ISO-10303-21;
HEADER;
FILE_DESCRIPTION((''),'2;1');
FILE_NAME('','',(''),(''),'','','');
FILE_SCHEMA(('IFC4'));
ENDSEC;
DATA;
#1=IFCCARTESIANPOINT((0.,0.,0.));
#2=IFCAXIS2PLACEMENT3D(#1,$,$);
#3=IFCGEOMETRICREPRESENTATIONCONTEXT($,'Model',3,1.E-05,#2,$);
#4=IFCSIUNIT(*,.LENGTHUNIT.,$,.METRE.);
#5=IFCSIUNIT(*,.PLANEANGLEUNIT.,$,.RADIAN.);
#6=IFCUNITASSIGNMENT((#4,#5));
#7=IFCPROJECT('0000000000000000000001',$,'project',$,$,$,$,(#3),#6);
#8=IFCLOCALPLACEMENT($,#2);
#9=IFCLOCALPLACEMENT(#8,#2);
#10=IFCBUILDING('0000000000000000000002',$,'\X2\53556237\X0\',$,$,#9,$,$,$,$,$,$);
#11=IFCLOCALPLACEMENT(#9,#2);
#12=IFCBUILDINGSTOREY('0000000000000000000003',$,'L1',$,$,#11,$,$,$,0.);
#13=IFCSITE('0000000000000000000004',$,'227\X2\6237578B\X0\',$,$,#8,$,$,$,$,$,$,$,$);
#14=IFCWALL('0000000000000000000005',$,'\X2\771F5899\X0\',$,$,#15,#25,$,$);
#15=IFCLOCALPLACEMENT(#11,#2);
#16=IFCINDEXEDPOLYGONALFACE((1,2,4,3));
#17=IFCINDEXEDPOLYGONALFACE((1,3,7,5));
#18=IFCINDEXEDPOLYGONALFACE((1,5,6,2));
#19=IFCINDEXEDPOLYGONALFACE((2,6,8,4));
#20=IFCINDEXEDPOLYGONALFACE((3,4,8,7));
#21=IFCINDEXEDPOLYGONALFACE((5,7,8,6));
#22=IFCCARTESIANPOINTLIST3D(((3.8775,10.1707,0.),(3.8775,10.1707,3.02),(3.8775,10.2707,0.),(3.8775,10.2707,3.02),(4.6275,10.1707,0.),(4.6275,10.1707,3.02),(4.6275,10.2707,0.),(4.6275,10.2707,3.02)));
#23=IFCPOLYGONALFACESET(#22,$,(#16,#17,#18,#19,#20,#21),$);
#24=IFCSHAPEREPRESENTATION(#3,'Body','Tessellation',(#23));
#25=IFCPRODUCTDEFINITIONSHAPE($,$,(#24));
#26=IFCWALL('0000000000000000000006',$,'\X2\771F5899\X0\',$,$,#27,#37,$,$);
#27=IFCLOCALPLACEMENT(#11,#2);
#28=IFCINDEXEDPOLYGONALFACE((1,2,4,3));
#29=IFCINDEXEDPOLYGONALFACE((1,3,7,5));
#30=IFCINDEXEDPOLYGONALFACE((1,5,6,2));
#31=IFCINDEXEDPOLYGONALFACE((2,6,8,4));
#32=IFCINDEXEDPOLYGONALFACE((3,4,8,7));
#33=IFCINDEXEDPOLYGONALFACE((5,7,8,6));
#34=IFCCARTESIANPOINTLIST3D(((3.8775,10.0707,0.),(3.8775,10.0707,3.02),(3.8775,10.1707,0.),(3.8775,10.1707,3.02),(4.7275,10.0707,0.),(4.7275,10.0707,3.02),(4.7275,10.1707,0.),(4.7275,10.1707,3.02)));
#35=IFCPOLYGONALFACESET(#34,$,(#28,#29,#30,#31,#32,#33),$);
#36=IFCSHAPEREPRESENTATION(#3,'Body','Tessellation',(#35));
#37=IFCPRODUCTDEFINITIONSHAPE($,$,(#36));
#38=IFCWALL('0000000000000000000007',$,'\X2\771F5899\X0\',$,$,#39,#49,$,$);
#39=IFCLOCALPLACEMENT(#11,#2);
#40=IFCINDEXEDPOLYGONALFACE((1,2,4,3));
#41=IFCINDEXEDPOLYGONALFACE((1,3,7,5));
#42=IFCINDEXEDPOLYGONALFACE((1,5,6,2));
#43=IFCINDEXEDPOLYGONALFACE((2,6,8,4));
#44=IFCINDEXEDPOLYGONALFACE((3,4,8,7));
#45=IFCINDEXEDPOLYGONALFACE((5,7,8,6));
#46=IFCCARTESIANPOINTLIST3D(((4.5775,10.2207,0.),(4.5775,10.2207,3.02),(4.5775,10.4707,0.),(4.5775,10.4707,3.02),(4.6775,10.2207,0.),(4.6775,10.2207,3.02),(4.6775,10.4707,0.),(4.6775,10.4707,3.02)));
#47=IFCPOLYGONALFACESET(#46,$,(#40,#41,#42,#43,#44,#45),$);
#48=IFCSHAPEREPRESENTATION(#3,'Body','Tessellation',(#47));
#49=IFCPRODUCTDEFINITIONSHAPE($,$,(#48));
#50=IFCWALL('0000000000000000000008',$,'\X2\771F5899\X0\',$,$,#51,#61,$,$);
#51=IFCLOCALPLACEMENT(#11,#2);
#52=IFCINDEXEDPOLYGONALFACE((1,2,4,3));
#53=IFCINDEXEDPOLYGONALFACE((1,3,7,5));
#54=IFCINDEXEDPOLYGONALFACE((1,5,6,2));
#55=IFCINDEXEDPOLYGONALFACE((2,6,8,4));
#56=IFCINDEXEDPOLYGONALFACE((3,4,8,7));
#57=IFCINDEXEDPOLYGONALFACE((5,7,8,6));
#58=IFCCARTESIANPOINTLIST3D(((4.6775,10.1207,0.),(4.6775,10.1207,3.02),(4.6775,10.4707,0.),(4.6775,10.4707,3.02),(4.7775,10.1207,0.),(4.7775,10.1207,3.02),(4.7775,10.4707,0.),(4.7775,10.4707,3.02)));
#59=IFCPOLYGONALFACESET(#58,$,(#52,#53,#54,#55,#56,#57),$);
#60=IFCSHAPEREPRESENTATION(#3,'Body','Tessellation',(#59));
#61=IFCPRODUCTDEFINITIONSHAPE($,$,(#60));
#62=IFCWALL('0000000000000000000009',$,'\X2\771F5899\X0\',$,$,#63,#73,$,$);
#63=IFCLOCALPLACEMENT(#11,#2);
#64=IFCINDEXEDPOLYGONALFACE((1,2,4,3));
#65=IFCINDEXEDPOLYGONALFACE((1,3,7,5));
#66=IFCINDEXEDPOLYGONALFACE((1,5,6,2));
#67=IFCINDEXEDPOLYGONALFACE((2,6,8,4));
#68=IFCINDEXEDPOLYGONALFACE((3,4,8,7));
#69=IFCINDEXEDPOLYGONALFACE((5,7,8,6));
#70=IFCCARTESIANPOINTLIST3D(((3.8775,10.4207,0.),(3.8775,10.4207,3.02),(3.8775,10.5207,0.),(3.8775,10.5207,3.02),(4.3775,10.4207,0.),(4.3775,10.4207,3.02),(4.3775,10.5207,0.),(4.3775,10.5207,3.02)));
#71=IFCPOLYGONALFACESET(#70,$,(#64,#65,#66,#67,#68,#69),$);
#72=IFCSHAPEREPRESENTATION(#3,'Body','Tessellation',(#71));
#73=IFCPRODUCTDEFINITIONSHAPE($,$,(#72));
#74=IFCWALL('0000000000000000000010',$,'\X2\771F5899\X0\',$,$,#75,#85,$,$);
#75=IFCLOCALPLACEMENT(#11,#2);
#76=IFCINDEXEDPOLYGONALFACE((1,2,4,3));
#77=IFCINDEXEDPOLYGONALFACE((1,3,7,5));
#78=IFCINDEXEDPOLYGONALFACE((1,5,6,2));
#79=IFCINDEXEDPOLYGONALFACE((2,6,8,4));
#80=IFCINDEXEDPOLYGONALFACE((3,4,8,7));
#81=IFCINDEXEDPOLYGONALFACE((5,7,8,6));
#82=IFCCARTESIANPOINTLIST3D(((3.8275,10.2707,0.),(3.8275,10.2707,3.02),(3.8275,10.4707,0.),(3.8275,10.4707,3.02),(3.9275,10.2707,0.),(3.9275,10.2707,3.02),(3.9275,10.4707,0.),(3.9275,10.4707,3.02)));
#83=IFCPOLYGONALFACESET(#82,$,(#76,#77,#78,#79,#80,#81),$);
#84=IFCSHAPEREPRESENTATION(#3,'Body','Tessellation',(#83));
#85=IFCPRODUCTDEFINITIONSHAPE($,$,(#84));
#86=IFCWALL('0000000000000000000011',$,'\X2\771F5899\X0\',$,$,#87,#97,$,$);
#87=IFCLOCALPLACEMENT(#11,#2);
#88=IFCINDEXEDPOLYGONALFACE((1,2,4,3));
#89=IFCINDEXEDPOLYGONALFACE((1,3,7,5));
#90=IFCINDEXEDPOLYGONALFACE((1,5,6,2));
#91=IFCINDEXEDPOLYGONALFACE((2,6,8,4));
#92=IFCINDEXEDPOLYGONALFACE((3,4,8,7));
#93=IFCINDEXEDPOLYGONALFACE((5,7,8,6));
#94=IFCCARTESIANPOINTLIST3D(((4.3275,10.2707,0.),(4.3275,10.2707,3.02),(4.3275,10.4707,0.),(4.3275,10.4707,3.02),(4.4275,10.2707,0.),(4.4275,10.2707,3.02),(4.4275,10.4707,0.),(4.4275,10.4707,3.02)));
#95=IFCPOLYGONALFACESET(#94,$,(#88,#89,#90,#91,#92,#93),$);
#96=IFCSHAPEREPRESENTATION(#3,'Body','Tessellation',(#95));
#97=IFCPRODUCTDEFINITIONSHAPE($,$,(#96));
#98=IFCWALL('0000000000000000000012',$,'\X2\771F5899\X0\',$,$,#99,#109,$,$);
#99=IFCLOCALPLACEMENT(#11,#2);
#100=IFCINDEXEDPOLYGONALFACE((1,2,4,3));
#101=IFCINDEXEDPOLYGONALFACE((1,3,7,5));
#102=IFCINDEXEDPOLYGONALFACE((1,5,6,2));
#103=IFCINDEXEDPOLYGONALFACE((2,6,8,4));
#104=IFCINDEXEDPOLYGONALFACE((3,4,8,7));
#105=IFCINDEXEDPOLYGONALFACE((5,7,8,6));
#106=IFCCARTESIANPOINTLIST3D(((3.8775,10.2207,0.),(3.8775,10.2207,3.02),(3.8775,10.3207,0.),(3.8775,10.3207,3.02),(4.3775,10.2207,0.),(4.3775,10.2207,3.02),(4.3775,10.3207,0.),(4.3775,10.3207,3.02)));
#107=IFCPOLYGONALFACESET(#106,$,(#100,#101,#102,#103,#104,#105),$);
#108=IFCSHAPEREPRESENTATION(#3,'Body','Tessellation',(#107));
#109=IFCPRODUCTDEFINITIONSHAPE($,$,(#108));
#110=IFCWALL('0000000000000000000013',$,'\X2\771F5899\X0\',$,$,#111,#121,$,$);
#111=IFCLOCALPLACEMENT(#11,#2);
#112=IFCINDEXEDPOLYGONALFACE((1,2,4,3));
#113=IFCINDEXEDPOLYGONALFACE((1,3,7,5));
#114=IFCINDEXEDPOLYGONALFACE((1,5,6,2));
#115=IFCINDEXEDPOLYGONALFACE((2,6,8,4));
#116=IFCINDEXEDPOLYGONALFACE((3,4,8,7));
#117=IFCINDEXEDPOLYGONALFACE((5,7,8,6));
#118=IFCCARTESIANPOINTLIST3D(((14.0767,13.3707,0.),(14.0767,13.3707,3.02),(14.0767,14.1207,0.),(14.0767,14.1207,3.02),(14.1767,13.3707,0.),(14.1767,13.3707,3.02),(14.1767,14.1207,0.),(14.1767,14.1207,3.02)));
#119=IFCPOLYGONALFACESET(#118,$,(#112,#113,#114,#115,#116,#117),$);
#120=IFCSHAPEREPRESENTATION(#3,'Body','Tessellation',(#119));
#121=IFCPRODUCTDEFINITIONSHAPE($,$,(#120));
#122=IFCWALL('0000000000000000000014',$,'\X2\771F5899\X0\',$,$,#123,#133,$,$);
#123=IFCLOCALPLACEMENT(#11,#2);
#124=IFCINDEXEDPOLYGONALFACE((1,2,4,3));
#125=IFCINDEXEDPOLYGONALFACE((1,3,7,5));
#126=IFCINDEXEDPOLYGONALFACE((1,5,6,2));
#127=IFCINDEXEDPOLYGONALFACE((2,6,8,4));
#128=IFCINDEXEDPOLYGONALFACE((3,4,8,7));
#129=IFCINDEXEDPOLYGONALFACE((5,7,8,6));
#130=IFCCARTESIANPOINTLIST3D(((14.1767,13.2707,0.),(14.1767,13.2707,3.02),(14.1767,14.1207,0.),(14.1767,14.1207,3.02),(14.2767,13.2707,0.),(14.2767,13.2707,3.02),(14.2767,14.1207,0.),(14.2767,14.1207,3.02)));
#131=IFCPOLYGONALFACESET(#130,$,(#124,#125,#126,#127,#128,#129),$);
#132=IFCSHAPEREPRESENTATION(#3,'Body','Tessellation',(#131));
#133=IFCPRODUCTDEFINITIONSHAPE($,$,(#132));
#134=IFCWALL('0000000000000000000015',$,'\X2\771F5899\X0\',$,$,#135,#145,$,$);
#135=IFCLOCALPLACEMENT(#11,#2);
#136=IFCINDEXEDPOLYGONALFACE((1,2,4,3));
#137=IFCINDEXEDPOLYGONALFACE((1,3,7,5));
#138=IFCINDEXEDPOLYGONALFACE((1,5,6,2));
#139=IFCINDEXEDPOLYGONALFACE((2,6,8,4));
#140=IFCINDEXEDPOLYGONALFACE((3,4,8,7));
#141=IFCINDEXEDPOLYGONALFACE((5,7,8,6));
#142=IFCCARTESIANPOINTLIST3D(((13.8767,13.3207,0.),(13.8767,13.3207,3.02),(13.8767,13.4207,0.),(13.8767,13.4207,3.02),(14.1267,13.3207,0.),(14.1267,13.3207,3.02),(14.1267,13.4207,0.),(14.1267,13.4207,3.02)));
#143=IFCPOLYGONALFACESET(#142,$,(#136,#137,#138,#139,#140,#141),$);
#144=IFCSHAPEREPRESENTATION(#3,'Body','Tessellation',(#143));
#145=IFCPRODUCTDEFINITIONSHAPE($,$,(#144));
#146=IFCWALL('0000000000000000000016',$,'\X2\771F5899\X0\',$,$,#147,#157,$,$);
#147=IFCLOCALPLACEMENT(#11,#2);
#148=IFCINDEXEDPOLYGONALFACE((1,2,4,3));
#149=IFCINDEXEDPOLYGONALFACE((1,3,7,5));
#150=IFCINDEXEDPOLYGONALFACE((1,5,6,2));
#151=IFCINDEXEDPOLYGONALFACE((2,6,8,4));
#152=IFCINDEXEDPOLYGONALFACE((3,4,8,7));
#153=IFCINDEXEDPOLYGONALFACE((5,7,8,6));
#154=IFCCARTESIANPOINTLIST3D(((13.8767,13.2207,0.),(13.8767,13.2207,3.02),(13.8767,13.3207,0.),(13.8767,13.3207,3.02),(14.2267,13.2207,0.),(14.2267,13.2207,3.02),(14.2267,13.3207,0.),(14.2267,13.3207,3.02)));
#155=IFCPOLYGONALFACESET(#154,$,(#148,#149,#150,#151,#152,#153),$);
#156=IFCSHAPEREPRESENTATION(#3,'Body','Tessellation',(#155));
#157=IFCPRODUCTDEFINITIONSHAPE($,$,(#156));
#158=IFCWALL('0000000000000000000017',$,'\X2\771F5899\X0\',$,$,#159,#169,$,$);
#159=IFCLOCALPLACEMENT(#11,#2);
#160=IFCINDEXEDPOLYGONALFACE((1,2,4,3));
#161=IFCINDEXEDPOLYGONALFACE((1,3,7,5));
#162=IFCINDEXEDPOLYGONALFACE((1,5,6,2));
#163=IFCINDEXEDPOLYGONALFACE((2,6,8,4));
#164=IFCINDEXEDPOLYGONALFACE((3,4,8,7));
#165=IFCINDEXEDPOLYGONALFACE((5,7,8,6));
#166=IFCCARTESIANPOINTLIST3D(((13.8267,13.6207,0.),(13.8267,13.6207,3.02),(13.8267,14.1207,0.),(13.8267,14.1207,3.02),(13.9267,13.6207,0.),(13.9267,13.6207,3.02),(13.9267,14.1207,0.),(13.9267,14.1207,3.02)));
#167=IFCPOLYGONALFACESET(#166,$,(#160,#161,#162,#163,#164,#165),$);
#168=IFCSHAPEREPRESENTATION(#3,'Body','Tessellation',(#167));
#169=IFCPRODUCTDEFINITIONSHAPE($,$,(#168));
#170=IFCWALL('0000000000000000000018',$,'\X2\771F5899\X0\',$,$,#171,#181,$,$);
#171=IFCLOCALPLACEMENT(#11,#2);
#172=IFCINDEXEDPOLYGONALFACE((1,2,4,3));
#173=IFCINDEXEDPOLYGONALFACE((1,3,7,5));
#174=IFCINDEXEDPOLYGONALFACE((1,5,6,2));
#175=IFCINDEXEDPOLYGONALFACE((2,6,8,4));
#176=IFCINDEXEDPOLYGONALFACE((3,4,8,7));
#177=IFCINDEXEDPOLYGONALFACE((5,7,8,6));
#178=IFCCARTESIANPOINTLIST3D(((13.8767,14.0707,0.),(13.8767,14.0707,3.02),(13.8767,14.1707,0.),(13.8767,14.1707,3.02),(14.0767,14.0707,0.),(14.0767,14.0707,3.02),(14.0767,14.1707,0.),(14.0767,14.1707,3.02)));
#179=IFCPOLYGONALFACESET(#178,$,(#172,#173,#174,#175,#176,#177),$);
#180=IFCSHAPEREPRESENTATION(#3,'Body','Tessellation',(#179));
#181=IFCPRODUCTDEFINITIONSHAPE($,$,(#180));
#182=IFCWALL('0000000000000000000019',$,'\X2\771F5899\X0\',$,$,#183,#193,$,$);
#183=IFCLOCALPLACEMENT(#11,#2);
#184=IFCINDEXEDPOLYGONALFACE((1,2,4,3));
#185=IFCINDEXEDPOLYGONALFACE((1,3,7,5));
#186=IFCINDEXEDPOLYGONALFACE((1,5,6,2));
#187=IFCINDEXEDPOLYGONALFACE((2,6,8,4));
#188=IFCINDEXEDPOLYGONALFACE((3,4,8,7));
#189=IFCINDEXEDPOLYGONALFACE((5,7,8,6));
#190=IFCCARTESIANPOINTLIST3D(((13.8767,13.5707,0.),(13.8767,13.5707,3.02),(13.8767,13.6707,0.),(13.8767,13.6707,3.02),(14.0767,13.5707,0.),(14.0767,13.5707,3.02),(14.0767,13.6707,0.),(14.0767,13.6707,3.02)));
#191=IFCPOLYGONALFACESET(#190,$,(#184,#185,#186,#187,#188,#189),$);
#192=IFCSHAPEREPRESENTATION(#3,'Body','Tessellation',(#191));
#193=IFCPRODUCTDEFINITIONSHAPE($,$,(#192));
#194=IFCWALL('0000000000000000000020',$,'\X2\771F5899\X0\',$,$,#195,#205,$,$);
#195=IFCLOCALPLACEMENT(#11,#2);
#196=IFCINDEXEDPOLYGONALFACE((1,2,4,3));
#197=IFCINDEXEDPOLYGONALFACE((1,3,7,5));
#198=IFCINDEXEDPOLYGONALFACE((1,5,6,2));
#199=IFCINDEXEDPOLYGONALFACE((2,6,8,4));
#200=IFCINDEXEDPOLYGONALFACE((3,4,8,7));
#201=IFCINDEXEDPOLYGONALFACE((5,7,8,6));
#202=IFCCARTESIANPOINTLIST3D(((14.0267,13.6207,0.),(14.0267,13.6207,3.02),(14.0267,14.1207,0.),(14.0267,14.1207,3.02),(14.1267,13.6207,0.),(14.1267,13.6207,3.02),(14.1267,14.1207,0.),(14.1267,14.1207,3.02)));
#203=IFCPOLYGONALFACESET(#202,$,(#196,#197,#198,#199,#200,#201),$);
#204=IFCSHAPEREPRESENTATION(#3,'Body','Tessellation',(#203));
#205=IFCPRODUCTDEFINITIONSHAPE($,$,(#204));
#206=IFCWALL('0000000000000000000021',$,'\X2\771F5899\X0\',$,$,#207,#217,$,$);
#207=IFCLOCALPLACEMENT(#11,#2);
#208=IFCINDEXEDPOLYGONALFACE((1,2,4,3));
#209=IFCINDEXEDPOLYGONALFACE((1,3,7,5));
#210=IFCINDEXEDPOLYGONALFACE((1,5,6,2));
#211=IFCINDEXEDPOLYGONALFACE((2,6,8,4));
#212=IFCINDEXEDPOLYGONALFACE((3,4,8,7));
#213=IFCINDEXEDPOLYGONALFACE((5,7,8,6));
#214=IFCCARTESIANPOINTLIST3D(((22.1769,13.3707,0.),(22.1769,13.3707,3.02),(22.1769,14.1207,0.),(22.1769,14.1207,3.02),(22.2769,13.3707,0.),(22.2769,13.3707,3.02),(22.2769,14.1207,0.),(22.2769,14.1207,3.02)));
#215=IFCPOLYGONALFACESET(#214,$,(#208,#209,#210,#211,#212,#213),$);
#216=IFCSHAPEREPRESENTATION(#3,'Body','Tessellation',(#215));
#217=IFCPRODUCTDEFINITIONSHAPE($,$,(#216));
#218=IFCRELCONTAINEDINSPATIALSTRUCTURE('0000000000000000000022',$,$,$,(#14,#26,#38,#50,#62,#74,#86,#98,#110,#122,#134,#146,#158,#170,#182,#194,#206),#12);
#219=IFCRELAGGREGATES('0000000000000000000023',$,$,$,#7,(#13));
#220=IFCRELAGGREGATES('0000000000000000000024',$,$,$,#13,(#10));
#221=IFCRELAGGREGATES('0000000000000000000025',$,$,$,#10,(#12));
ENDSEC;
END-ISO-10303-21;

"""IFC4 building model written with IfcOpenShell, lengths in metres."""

from ifc_helpers import new_model, si_unit, origin, place, context, project, spatial, polyline, outline, extrude, element, save


model = new_model("IFC4")

# Units and contexts
model_context = context("Model", 3, precision=1e-05, world=origin())
ifc_project = project(units=[si_unit("LENGTHUNIT", "METRE"), si_unit("PLANEANGLEUNIT", "RADIAN")], contexts=[model_context])

# Site, building, storey
site_placement = place(None, origin())
site = spatial("IfcSite", under=ifc_project, at=site_placement, Name="227户型")
building_placement = place(site_placement, origin())
building = spatial("IfcBuilding", under=site, at=building_placement, Name="单户")
storey_placement = place(building_placement, origin())
storey = spatial("IfcBuildingStorey", under=building, at=storey_placement, Name="L1", Elevation=0.0)

# Walls
wall_1_placement = place(storey_placement, origin())
element("IfcWall", 1, at=wall_1_placement, inside=storey, Name="真墙", context=model_context, shape_type="SweptSolid", body=[
    extrude(outline(polyline([(4.6275, 10.1707), (3.8775, 10.1707), (3.8775, 10.2707), (4.6275, 10.2707), (4.6275, 10.1707)])), origin(), (0.0, 0.0, 1.0), 3.02),
])
wall_2_placement = place(storey_placement, origin())
element("IfcWall", 2, at=wall_2_placement, inside=storey, Name="真墙", context=model_context, shape_type="SweptSolid", body=[
    extrude(outline(polyline([(3.8775, 10.1707), (4.7275, 10.1707), (4.7275, 10.0707), (3.8775, 10.0707), (3.8775, 10.1707)])), origin(), (0.0, 0.0, 1.0), 3.02),
])
wall_3_placement = place(storey_placement, origin())
element("IfcWall", 3, at=wall_3_placement, inside=storey, Name="真墙", context=model_context, shape_type="SweptSolid", body=[
    extrude(outline(polyline([(4.5775, 10.2207), (4.5775, 10.4707), (4.6775, 10.4707), (4.6775, 10.2207), (4.5775, 10.2207)])), origin(), (0.0, 0.0, 1.0), 3.02),
])
wall_4_placement = place(storey_placement, origin())
element("IfcWall", 4, at=wall_4_placement, inside=storey, Name="真墙", context=model_context, shape_type="SweptSolid", body=[
    extrude(outline(polyline([(4.6775, 10.1207), (4.6775, 10.4707), (4.7775, 10.4707), (4.7775, 10.1207), (4.6775, 10.1207)])), origin(), (0.0, 0.0, 1.0), 3.02),
])
wall_5_placement = place(storey_placement, origin())
element("IfcWall", 5, at=wall_5_placement, inside=storey, Name="真墙", context=model_context, shape_type="SweptSolid", body=[
    extrude(outline(polyline([(4.3775, 10.4207), (3.8775, 10.4207), (3.8775, 10.5207), (4.3775, 10.5207), (4.3775, 10.4207)])), origin(), (0.0, 0.0, 1.0), 3.02),
])
wall_6_placement = place(storey_placement, origin())
element("IfcWall", 6, at=wall_6_placement, inside=storey, Name="真墙", context=model_context, shape_type="SweptSolid", body=[
    extrude(outline(polyline([(3.9275, 10.4707), (3.9275, 10.2707), (3.8275, 10.2707), (3.8275, 10.4707), (3.9275, 10.4707)])), origin(), (0.0, 0.0, 1.0), 3.02),
])
wall_7_placement = place(storey_placement, origin())
element("IfcWall", 7, at=wall_7_placement, inside=storey, Name="真墙", context=model_context, shape_type="SweptSolid", body=[
    extrude(outline(polyline([(4.4275, 10.4707), (4.4275, 10.2707), (4.3275, 10.2707), (4.3275, 10.4707), (4.4275, 10.4707)])), origin(), (0.0, 0.0, 1.0), 3.02),
])
wall_8_placement = place(storey_placement, origin())
element("IfcWall", 8, at=wall_8_placement, inside=storey, Name="真墙", context=model_context, shape_type="SweptSolid", body=[
    extrude(outline(polyline([(4.3775, 10.2207), (3.8775, 10.2207), (3.8775, 10.3207), (4.3775, 10.3207), (4.3775, 10.2207)])), origin(), (0.0, 0.0, 1.0), 3.02),
])
wall_9_placement = place(storey_placement, origin())
element("IfcWall", 9, at=wall_9_placement, inside=storey, Name="真墙", context=model_context, shape_type="SweptSolid", body=[
    extrude(outline(polyline([(14.0767, 13.3707), (14.0767, 14.1207), (14.1767, 14.1207), (14.1767, 13.3707), (14.0767, 13.3707)])), origin(), (0.0, 0.0, 1.0), 3.02),
])
wall_10_placement = place(storey_placement, origin())
element("IfcWall", 10, at=wall_10_placement, inside=storey, Name="真墙", context=model_context, shape_type="SweptSolid", body=[
    extrude(outline(polyline([(14.2767, 14.1207), (14.2767, 13.2707), (14.1767, 13.2707), (14.1767, 14.1207), (14.2767, 14.1207)])), origin(), (0.0, 0.0, 1.0), 3.02),
])
wall_11_placement = place(storey_placement, origin())
element("IfcWall", 11, at=wall_11_placement, inside=storey, Name="真墙", context=model_context, shape_type="SweptSolid", body=[
    extrude(outline(polyline([(14.1267, 13.3207), (13.8767, 13.3207), (13.8767, 13.4207), (14.1267, 13.4207), (14.1267, 13.3207)])), origin(), (0.0, 0.0, 1.0), 3.02),
])
wall_12_placement = place(storey_placement, origin())
element("IfcWall", 12, at=wall_12_placement, inside=storey, Name="真墙", context=model_context, shape_type="SweptSolid", body=[
    extrude(outline(polyline([(14.2267, 13.2207), (13.8767, 13.2207), (13.8767, 13.3207), (14.2267, 13.3207), (14.2267, 13.2207)])), origin(), (0.0, 0.0, 1.0), 3.02),
])
wall_13_placement = place(storey_placement, origin())
element("IfcWall", 13, at=wall_13_placement, inside=storey, Name="真墙", context=model_context, shape_type="SweptSolid", body=[
    extrude(outline(polyline([(13.8267, 13.6207), (13.8267, 14.1207), (13.9267, 14.1207), (13.9267, 13.6207), (13.8267, 13.6207)])), origin(), (0.0, 0.0, 1.0), 3.02),
])
wall_14_placement = place(storey_placement, origin())
element("IfcWall", 14, at=wall_14_placement, inside=storey, Name="真墙", context=model_context, shape_type="SweptSolid", body=[
    extrude(outline(polyline([(13.8767, 14.1707), (14.0767, 14.1707), (14.0767, 14.0707), (13.8767, 14.0707), (13.8767, 14.1707)])), origin(), (0.0, 0.0, 1.0), 3.02),
])
wall_15_placement = place(storey_placement, origin())
element("IfcWall", 15, at=wall_15_placement, inside=storey, Name="真墙", context=model_context, shape_type="SweptSolid", body=[
    extrude(outline(polyline([(13.8767, 13.6707), (14.0767, 13.6707), (14.0767, 13.5707), (13.8767, 13.5707), (13.8767, 13.6707)])), origin(), (0.0, 0.0, 1.0), 3.02),
])
wall_16_placement = place(storey_placement, origin())
element("IfcWall", 16, at=wall_16_placement, inside=storey, Name="真墙", context=model_context, shape_type="SweptSolid", body=[
    extrude(outline(polyline([(14.0267, 13.6207), (14.0267, 14.1207), (14.1267, 14.1207), (14.1267, 13.6207), (14.0267, 13.6207)])), origin(), (0.0, 0.0, 1.0), 3.02),
])
wall_17_placement = place(storey_placement, origin())
element("IfcWall", 17, at=wall_17_placement, inside=storey, Name="真墙", context=model_context, shape_type="SweptSolid", body=[
    extrude(outline(polyline([(22.1769, 13.3707), (22.1769, 14.1207), (22.2769, 14.1207), (22.2769, 13.3707), (22.1769, 13.3707)])), origin(), (0.0, 0.0, 1.0), 3.02),
])

save(model, "model.ifc")
